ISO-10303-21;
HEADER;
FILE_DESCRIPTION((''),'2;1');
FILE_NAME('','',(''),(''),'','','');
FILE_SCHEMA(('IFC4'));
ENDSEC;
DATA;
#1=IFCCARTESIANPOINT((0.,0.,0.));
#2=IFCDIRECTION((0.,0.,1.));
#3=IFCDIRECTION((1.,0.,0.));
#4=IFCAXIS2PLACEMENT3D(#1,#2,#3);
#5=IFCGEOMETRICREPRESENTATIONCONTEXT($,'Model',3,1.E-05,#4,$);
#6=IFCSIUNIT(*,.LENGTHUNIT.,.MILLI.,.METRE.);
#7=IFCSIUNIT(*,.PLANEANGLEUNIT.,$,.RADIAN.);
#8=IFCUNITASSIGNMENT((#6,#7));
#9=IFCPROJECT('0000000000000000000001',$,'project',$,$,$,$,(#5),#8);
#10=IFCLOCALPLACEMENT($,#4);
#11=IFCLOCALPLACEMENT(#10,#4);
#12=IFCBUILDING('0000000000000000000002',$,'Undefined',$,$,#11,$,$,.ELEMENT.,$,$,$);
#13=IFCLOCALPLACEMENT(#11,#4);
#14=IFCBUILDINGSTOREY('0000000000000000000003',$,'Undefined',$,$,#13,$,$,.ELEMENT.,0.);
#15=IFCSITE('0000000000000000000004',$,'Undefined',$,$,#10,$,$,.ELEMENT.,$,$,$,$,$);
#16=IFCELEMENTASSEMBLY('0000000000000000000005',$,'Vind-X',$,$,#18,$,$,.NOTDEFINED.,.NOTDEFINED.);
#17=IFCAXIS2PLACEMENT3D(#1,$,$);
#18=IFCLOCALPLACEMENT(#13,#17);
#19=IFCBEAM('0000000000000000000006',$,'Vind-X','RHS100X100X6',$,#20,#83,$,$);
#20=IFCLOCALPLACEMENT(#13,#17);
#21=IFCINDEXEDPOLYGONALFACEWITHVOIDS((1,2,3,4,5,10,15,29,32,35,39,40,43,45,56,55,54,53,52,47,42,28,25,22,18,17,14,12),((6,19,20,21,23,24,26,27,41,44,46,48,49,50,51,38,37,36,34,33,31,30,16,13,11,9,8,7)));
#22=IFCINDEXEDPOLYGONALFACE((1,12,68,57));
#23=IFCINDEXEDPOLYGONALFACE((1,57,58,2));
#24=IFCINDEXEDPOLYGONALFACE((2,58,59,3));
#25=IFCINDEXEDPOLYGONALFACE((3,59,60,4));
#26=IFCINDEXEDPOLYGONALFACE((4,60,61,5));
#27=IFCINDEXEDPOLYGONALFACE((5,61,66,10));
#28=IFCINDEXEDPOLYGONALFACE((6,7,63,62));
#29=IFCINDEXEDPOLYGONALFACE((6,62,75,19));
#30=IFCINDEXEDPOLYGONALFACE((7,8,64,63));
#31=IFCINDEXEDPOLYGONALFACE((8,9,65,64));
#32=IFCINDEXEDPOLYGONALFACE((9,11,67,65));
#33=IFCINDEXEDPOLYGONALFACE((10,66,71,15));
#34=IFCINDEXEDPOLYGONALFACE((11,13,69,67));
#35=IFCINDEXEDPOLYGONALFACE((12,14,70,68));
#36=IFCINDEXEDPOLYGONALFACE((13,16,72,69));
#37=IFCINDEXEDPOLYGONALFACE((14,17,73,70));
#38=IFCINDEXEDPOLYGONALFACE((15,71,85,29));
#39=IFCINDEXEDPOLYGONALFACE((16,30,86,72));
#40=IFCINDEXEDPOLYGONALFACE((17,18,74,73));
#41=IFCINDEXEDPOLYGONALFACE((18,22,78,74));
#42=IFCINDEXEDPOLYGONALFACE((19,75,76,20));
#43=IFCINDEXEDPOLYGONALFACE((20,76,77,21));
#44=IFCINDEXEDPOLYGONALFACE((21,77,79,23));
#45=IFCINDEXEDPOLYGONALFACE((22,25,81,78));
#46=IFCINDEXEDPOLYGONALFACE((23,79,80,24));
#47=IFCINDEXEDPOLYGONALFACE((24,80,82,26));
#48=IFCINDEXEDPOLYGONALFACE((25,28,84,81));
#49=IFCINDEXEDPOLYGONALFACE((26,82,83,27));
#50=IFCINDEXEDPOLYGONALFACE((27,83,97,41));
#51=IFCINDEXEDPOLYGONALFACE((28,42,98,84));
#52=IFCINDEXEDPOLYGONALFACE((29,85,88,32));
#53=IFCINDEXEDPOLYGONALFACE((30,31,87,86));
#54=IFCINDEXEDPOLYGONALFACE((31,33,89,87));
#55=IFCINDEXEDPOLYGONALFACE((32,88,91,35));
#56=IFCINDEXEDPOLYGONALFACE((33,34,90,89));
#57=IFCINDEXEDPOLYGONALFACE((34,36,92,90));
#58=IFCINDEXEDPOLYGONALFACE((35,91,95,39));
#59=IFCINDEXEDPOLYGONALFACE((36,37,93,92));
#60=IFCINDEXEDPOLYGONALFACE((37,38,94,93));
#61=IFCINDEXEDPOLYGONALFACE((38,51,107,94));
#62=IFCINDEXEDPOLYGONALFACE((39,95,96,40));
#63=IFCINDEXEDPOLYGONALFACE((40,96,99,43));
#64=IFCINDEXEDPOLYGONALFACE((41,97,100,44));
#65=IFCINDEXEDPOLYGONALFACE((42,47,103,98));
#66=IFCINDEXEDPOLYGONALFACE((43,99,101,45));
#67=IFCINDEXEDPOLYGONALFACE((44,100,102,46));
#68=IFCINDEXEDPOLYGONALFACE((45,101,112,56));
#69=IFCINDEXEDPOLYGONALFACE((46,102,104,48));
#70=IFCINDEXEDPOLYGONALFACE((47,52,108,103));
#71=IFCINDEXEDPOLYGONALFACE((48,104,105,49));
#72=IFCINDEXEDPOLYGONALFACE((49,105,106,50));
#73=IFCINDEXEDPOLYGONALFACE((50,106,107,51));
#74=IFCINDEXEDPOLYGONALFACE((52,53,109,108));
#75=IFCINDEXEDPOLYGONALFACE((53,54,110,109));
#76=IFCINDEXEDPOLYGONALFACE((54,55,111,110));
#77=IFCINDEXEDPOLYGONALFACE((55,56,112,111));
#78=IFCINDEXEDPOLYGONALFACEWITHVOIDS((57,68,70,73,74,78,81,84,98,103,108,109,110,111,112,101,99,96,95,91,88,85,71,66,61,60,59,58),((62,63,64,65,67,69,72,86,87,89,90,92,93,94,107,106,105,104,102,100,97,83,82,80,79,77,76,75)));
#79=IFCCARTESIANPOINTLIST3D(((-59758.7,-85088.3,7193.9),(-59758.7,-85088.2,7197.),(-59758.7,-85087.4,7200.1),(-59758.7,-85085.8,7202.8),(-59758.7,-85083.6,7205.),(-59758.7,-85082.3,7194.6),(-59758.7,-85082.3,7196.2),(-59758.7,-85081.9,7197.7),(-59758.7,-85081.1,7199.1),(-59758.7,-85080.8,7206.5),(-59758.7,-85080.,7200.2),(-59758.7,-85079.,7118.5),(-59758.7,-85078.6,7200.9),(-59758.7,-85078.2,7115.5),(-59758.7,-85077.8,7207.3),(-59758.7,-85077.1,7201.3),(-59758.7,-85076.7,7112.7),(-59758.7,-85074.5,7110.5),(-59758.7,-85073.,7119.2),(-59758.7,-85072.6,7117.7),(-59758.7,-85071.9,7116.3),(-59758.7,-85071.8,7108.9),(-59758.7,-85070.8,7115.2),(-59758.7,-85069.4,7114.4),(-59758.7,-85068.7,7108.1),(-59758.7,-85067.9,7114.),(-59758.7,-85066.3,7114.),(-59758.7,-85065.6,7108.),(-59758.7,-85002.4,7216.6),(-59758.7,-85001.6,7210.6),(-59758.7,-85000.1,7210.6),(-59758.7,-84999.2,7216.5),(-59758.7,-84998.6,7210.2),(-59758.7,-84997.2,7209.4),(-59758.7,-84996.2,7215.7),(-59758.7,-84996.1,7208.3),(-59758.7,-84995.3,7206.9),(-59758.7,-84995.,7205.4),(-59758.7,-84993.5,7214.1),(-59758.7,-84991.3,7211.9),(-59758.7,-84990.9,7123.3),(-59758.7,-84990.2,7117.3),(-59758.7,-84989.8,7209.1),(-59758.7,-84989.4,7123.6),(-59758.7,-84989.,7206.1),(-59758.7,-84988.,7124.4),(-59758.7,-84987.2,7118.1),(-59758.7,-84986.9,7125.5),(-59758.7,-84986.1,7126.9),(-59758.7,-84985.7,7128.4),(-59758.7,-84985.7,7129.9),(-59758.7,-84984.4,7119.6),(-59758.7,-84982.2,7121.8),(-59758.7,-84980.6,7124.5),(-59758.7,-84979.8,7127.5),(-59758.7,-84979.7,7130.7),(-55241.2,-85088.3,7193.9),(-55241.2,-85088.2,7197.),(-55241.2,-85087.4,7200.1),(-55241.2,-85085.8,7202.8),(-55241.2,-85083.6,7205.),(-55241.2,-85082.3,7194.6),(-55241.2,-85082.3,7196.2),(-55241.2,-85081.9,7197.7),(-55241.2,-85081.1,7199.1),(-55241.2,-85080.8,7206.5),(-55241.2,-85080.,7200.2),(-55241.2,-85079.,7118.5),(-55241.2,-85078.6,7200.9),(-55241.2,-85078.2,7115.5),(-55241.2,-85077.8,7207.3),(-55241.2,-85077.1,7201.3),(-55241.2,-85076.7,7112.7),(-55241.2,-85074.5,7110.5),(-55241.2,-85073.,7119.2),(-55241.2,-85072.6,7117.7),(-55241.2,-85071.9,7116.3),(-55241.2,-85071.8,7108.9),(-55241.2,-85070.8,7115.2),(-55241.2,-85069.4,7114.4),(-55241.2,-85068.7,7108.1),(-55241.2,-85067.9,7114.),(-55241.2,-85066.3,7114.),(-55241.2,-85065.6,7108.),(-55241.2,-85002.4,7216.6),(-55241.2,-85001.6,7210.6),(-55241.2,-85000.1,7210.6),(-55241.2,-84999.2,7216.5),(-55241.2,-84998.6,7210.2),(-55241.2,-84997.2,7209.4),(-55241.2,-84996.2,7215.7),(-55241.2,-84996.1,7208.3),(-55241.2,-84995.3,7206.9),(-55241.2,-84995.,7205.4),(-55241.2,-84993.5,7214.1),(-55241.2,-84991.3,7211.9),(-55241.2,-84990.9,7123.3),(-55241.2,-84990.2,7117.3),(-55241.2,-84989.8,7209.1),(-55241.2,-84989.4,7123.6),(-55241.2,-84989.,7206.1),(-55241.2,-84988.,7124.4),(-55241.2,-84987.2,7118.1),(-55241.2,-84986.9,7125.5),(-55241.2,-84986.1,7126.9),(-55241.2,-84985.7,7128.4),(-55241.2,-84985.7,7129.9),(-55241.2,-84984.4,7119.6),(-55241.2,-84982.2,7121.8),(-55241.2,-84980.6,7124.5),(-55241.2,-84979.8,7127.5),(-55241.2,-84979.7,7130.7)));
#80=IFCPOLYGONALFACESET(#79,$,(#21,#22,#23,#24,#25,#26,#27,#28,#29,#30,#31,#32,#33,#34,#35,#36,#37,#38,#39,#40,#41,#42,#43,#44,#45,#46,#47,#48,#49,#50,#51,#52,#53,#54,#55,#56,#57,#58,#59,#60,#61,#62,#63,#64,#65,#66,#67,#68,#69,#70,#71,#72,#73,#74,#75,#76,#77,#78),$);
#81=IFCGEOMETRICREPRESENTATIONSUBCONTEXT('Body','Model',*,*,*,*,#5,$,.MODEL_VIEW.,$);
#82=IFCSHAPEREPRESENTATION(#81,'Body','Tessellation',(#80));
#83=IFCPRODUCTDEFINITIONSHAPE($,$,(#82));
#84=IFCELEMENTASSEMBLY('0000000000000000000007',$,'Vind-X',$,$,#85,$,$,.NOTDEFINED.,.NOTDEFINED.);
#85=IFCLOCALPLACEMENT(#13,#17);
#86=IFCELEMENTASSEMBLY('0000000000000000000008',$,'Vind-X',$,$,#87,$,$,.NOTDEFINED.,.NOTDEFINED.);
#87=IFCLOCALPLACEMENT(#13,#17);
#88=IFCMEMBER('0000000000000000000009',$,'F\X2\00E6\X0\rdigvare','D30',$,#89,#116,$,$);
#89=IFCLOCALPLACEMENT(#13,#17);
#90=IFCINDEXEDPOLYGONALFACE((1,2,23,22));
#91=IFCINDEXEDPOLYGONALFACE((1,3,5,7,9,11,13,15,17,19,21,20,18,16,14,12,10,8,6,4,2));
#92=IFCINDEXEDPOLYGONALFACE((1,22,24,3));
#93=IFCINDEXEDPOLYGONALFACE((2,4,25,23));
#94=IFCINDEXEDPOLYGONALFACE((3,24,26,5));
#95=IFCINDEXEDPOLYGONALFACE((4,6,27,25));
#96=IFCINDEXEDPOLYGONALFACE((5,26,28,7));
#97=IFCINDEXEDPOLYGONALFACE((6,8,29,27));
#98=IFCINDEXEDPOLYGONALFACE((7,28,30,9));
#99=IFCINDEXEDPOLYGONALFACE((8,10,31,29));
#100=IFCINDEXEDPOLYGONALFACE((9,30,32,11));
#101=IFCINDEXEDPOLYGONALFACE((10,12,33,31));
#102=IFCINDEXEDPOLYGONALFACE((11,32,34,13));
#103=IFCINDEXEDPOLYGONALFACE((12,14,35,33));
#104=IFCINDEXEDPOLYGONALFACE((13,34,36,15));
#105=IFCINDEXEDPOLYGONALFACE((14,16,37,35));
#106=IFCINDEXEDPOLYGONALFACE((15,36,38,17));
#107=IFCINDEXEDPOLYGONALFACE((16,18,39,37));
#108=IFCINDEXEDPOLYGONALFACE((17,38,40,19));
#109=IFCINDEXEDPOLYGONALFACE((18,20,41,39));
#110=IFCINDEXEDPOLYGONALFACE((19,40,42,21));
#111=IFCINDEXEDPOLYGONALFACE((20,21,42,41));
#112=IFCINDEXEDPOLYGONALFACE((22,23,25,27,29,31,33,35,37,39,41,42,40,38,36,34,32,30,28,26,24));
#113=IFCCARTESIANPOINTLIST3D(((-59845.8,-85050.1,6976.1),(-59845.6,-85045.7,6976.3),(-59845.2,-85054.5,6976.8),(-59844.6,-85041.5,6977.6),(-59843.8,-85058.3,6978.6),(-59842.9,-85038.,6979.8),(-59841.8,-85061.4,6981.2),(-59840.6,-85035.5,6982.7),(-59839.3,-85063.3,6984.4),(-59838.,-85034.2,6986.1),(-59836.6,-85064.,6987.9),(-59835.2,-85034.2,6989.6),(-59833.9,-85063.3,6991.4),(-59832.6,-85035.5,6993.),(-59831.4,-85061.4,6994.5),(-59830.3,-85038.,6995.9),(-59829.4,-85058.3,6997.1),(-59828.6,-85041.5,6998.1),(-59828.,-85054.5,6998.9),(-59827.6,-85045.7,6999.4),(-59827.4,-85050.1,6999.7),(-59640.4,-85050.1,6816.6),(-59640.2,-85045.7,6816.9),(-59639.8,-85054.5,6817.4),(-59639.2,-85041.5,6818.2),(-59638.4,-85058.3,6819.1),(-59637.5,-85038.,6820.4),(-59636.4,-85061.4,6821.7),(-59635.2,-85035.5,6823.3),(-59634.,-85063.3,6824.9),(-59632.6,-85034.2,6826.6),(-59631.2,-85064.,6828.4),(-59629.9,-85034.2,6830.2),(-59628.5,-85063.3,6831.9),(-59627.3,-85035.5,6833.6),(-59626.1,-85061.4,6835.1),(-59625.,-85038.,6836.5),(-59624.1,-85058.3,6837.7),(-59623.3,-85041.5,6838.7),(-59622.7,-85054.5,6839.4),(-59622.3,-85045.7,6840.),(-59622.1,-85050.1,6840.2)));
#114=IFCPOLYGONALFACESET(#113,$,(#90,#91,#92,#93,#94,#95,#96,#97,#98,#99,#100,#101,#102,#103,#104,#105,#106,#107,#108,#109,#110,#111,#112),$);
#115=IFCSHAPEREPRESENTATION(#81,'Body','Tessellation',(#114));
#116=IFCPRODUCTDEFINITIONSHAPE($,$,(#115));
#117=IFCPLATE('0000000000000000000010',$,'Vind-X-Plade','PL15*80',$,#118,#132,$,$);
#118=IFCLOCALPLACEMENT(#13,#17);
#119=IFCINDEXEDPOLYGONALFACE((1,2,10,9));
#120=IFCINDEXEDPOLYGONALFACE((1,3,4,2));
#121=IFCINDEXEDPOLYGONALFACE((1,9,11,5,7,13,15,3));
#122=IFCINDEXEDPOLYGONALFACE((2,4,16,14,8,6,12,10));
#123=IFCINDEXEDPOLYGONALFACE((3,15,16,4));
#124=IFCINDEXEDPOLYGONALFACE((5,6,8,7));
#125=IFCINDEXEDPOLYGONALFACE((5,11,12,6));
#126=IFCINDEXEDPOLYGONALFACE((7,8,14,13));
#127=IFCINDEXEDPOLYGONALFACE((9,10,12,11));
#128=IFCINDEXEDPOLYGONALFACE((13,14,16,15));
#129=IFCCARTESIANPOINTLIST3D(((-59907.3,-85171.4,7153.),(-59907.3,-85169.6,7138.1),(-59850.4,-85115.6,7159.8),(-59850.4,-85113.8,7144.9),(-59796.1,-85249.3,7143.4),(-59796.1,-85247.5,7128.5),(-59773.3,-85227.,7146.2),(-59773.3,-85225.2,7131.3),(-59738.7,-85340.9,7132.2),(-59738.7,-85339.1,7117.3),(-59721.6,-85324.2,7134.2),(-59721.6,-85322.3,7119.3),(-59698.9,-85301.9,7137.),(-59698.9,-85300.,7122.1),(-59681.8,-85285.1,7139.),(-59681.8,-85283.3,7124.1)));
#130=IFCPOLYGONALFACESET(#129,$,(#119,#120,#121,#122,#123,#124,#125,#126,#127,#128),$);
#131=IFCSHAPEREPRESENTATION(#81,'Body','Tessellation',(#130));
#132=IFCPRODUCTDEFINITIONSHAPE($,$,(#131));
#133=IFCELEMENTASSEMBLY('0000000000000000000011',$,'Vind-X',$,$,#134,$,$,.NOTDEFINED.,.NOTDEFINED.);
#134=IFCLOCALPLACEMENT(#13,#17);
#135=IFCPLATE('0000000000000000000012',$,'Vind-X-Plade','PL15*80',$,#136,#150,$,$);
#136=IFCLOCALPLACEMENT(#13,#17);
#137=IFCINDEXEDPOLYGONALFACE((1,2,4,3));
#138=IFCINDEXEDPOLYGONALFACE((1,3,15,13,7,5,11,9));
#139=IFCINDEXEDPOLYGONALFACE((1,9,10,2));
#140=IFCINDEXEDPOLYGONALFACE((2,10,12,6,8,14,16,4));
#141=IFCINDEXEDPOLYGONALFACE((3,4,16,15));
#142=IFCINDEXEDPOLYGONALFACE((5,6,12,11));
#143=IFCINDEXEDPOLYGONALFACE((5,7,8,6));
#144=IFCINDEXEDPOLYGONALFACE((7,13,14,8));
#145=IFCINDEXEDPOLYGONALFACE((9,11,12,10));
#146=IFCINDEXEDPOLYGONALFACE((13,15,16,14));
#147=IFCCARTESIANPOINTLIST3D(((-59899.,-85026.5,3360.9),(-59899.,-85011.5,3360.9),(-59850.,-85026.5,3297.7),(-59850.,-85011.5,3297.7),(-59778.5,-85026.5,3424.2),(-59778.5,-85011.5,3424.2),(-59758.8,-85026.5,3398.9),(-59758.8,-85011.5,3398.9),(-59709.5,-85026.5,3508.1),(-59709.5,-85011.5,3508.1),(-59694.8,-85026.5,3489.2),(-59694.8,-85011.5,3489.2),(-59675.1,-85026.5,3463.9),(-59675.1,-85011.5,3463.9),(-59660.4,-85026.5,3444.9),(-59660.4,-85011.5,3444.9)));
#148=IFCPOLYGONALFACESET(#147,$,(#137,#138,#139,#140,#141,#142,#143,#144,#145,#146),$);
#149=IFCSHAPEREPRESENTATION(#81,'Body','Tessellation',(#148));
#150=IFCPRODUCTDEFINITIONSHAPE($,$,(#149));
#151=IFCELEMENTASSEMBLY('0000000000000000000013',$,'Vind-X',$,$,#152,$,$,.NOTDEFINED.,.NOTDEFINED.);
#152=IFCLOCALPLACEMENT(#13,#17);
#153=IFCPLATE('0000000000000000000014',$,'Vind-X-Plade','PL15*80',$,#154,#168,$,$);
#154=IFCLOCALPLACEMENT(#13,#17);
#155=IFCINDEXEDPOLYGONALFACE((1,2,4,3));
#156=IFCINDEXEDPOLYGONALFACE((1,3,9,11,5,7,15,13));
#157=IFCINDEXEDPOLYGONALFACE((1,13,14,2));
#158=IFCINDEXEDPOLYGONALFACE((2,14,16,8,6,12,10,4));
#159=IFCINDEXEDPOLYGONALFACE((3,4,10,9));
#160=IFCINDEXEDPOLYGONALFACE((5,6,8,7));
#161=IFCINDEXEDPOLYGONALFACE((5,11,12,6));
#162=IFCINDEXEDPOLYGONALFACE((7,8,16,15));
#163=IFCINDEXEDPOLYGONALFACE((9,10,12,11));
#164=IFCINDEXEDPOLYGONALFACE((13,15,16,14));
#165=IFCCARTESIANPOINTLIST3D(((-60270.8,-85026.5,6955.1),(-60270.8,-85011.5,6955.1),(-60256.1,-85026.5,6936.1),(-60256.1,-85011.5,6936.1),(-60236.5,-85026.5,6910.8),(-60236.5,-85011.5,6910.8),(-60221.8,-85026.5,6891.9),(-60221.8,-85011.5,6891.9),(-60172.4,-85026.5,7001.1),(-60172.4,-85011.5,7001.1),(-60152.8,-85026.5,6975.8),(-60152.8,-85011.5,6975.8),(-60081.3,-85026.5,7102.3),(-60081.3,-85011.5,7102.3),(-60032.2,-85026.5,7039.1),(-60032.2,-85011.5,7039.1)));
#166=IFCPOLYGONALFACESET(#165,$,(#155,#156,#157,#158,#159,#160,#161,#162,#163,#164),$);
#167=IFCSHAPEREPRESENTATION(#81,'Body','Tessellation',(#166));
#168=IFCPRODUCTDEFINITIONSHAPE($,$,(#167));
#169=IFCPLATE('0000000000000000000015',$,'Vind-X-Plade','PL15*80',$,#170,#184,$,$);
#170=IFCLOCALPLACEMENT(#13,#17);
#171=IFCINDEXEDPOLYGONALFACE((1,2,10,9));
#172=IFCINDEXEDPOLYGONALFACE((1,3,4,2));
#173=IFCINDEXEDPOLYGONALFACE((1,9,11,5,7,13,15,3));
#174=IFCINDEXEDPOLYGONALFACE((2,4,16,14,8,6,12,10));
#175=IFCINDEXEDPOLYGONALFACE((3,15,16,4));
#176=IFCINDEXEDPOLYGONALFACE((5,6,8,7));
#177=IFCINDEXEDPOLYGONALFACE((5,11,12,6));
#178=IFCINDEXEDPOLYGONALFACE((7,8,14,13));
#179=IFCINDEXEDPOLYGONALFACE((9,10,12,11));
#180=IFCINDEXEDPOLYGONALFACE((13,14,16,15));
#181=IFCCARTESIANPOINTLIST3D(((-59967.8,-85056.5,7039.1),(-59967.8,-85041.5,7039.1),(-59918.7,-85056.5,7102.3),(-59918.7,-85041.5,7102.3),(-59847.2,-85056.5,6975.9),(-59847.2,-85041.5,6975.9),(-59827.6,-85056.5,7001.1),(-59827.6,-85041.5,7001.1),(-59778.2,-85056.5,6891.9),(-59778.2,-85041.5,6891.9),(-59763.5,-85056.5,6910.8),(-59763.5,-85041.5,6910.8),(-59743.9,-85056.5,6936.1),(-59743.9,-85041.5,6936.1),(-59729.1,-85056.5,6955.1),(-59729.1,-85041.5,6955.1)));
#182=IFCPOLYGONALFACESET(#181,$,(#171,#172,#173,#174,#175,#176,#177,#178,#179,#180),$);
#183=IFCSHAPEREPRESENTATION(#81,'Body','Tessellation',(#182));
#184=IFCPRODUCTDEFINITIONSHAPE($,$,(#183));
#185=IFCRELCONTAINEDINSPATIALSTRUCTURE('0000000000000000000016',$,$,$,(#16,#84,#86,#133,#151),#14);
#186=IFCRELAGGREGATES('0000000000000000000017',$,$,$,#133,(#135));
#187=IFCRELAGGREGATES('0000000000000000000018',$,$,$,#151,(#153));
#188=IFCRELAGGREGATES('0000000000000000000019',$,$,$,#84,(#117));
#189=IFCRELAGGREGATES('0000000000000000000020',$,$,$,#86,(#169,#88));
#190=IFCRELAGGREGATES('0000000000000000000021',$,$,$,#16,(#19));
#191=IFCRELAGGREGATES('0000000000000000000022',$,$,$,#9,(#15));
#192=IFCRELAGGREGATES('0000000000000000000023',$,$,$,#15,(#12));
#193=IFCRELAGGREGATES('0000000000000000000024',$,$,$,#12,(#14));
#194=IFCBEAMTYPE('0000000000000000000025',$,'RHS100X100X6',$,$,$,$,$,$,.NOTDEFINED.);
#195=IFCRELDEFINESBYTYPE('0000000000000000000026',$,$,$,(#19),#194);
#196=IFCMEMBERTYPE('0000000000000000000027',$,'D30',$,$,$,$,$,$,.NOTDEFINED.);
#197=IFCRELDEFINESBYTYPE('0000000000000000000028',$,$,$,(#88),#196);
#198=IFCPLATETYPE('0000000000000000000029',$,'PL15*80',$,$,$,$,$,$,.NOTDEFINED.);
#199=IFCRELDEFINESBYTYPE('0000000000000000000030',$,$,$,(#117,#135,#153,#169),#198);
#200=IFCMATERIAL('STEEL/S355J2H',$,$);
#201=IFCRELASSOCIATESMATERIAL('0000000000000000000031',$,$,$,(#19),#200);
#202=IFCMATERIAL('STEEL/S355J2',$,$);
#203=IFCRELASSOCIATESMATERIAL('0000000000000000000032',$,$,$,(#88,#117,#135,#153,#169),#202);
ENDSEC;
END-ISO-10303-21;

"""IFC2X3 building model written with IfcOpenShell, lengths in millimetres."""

from ifc_helpers import new_model, si_unit, frame, origin_with_axes, origin_2d_with_axis, place, context, subcontext, project, spatial, polyline, hollow_rectangle, circle, outline, extrude, boolean, clip, halfspace, material, type_object, element, aggregate, save


model = new_model("IFC2X3")

# Units and contexts
model_context = context("Model", 3, precision=1e-05, world=origin_with_axes())
body_context = subcontext(model_context, "Body", "Model", "MODEL_VIEW")
ifc_project = project(units=[si_unit("LENGTHUNIT", "METRE", prefix="MILLI"), si_unit("PLANEANGLEUNIT", "RADIAN")], contexts=[model_context])

# Site, building, storey
site_placement = place(None, origin_with_axes())
site = spatial("IfcSite", under=ifc_project, at=site_placement, Name="Undefined", CompositionType="ELEMENT")
building_placement = place(site_placement, origin_with_axes())
building = spatial("IfcBuilding", under=site, at=building_placement, Name="Undefined", CompositionType="ELEMENT")
storey_placement = place(building_placement, origin_with_axes())
storey = spatial("IfcBuildingStorey", under=building, at=storey_placement, Name="Undefined", CompositionType="ELEMENT", Elevation=0.0)

# Shared definitions
ifc_material_1 = material(Name="STEEL/S355J2H")

# Element assembly, beam
assembly_1_placement = place(storey_placement, origin_with_axes())
assembly_1 = element("IfcElementAssembly", 1, at=assembly_1_placement, inside=storey, Name="Vind-X", AssemblyPlace="NOTDEFINED", PredefinedType="NOTDEFINED")
beam_type = type_object("IfcBeamType", Name="RHS100X100X6", PredefinedType="NOTDEFINED")
beam_placement = place(assembly_1_placement, frame((-59836.9, -85034.0, 7162.3), z_axis=(0.0, 0.992546, 0.121869), x_axis=(1.0, 0.0, 0.0)))
beam = element("IfcBeam", 2, at=beam_placement, type_object=beam_type, material=ifc_material_1, Name="Vind-X", Description="RHS100X100X6", context=body_context, shape_type="Clipping", body=[
    clip(clip(extrude(hollow_rectangle(XDim=100.0, YDim=100.0, WallThickness=6.0, InnerFilletRadius=6.0, OuterFilletRadius=12.0, at=origin_2d_with_axis()), frame((4674.6, 0.0, 0.0), z_axis=(-1.0, 0.0, 0.0), x_axis=(0.0, -1.0, 0.0)), (0.0, 0.0, 1.0), 4674.6), halfspace(frame((4595.6, 22.5, 0.0), z_axis=(-1.0, 0.0, 0.0), x_axis=(0.0, 0.0, 1.0)), True)), halfspace(frame((78.1, 22.5, 0.0), z_axis=(1.0, 0.0, 0.0), x_axis=(0.0, 0.0, -1.0)), True)),
])

# Element assembly
assembly_2_placement = place(storey_placement, origin_with_axes())
assembly_2 = element("IfcElementAssembly", 3, at=assembly_2_placement, inside=storey, Name="Vind-X", AssemblyPlace="NOTDEFINED", PredefinedType="NOTDEFINED")
ifc_material_2 = material(Name="STEEL/S355J2")
member_type = type_object("IfcMemberType", Name="D30", PredefinedType="NOTDEFINED")

# Element assembly, member
assembly_3_placement = place(storey_placement, origin_with_axes())
assembly_3 = element("IfcElementAssembly", 4, at=assembly_3_placement, inside=storey, Name="Vind-X", AssemblyPlace="NOTDEFINED", PredefinedType="NOTDEFINED")
member_1_placement = place(assembly_3_placement, frame((-59836.6, -85049.0, 6987.9), z_axis=(0.613314, 0.0, 0.789839), x_axis=(0.789839, 0.0, -0.613314)))
member_1 = element("IfcMember", 5, at=member_1_placement, type_object=member_type, material=ifc_material_2, Name="Færdigvare", Description="D30", context=body_context, shape_type="SweptSolid", body=[
    extrude(circle(Radius=15.0, at=origin_2d_with_axis()), frame((260.0, 0.0, 0.0), z_axis=(-1.0, 0.0, 0.0), x_axis=(0.0, -1.0, 0.0)), (0.0, 0.0, 1.0), 260.0),
])

# Plate
plate_type_1 = type_object("IfcPlateType", Name="PL15*80", PredefinedType="NOTDEFINED")
plate_1_placement = place(assembly_2_placement, frame((-59907.3, -85170.5, 7145.5), z_axis=(0.0, 0.121869, -0.992546), x_axis=(0.711592, 0.697356, 0.085625)))
plate_1 = element("IfcPlate", 6, at=plate_1_placement, type_object=plate_type_1, material=ifc_material_2, Name="Vind-X-Plade", Description="PL15*80", context=body_context, shape_type="CSG", body=[
    boolean("DIFFERENCE", extrude(outline(polyline([(0.0, 0.0), (80.0, 0.0), (80.0, 240.0), (0.0, 240.0), (0.0, 0.0)])), frame((0.0, 0.0, -7.5), z_axis=(0.0, 0.0, 1.0), x_axis=(1.0, 0.0, 0.0)), (0.0, 0.0, 1.0), 15.0), extrude(outline(polyline([(0.0, 0.0), (106.0, 0.0), (106.0, 32.0), (0.0, 32.0), (0.0, 0.0)])), frame((56.0, 240.0, 8.5), z_axis=(0.0, 0.0, -1.0), x_axis=(0.0, -1.0, 0.0)), (0.0, 0.0, 1.0), 17.0)),
])

# Element assemblies, plates
assembly_4_placement = place(storey_placement, origin_with_axes())
assembly_4 = element("IfcElementAssembly", 7, at=assembly_4_placement, inside=storey, Name="Vind-X", AssemblyPlace="NOTDEFINED", PredefinedType="NOTDEFINED")
plate_2_placement = place(assembly_4_placement, frame((-59850.0, -85019.0, 3297.7), z_axis=(0.0, 1.0, 0.0), x_axis=(-0.613349, 0.0, 0.789812)))
plate_2 = element("IfcPlate", 8, at=plate_2_placement, type_object=plate_type_1, material=ifc_material_2, Name="Vind-X-Plade", Description="PL15*80", context=body_context, shape_type="CSG", body=[
    boolean("DIFFERENCE", extrude(outline(polyline([(0.0, 0.0), (80.0, 0.0), (80.0, 240.0), (0.0, 240.0), (0.0, 0.0)])), frame((0.0, 0.0, -7.5), z_axis=(0.0, 0.0, 1.0), x_axis=(1.0, 0.0, 0.0)), (0.0, 0.0, 1.0), 15.0), extrude(outline(polyline([(0.0, 0.0), (106.0, 0.0), (106.0, 32.0), (0.0, 32.0), (0.0, 0.0)])), frame((56.0, 240.0, 8.5), z_axis=(0.0, 0.0, -1.0), x_axis=(0.0, -1.0, 0.0)), (0.0, 0.0, 1.0), 17.0)),
])
aggregate(assembly_4, [plate_2])
assembly_5_placement = place(storey_placement, origin_with_axes())
assembly_5 = element("IfcElementAssembly", 9, at=assembly_5_placement, inside=storey, Name="Vind-X", AssemblyPlace="NOTDEFINED", PredefinedType="NOTDEFINED")
plate_3_placement = place(assembly_5_placement, frame((-60032.2, -85019.0, 7039.1), z_axis=(0.0, -1.0, 0.0), x_axis=(-0.613349, 0.0, 0.789812)))
plate_3 = element("IfcPlate", 10, at=plate_3_placement, type_object=plate_type_1, material=ifc_material_2, Name="Vind-X-Plade", Description="PL15*80", context=body_context, shape_type="CSG", body=[
    boolean("DIFFERENCE", extrude(outline(polyline([(0.0, 0.0), (80.0, 0.0), (80.0, 240.0), (0.0, 240.0), (0.0, 0.0)])), frame((0.0, 0.0, -7.5), z_axis=(0.0, 0.0, 1.0), x_axis=(1.0, 0.0, 0.0)), (0.0, 0.0, 1.0), 15.0), extrude(outline(polyline([(0.0, 0.0), (106.0, 0.0), (106.0, 32.0), (0.0, 32.0), (0.0, 0.0)])), frame((56.0, 240.0, 8.5), z_axis=(0.0, 0.0, -1.0), x_axis=(0.0, -1.0, 0.0)), (0.0, 0.0, 1.0), 17.0)),
])
aggregate(assembly_5, [plate_3])

# Plate
plate_4_placement = place(assembly_3_placement, frame((-59967.8, -85049.0, 7039.1), z_axis=(0.0, 1.0, 0.0), x_axis=(0.613314, 0.0, 0.789839)))
plate_4 = element("IfcPlate", 11, at=plate_4_placement, type_object=plate_type_1, material=ifc_material_2, Name="Vind-X-Plade", Description="PL15*80", context=body_context, shape_type="CSG", body=[
    boolean("DIFFERENCE", extrude(outline(polyline([(0.0, 0.0), (80.0, 0.0), (80.0, 240.0), (0.0, 240.0), (0.0, 0.0)])), frame((0.0, 0.0, -7.5), z_axis=(0.0, 0.0, 1.0), x_axis=(1.0, 0.0, 0.0)), (0.0, 0.0, 1.0), 15.0), extrude(outline(polyline([(0.0, 0.0), (106.0, 0.0), (106.0, 32.0), (0.0, 32.0), (0.0, 0.0)])), frame((56.0, 240.0, 8.5), z_axis=(0.0, 0.0, -1.0), x_axis=(0.0, -1.0, 0.0)), (0.0, 0.0, 1.0), 17.0)),
])

aggregate(assembly_2, [plate_1])
aggregate(assembly_3, [plate_4, member_1])
aggregate(assembly_1, [beam])

save(model, "model.ifc")
